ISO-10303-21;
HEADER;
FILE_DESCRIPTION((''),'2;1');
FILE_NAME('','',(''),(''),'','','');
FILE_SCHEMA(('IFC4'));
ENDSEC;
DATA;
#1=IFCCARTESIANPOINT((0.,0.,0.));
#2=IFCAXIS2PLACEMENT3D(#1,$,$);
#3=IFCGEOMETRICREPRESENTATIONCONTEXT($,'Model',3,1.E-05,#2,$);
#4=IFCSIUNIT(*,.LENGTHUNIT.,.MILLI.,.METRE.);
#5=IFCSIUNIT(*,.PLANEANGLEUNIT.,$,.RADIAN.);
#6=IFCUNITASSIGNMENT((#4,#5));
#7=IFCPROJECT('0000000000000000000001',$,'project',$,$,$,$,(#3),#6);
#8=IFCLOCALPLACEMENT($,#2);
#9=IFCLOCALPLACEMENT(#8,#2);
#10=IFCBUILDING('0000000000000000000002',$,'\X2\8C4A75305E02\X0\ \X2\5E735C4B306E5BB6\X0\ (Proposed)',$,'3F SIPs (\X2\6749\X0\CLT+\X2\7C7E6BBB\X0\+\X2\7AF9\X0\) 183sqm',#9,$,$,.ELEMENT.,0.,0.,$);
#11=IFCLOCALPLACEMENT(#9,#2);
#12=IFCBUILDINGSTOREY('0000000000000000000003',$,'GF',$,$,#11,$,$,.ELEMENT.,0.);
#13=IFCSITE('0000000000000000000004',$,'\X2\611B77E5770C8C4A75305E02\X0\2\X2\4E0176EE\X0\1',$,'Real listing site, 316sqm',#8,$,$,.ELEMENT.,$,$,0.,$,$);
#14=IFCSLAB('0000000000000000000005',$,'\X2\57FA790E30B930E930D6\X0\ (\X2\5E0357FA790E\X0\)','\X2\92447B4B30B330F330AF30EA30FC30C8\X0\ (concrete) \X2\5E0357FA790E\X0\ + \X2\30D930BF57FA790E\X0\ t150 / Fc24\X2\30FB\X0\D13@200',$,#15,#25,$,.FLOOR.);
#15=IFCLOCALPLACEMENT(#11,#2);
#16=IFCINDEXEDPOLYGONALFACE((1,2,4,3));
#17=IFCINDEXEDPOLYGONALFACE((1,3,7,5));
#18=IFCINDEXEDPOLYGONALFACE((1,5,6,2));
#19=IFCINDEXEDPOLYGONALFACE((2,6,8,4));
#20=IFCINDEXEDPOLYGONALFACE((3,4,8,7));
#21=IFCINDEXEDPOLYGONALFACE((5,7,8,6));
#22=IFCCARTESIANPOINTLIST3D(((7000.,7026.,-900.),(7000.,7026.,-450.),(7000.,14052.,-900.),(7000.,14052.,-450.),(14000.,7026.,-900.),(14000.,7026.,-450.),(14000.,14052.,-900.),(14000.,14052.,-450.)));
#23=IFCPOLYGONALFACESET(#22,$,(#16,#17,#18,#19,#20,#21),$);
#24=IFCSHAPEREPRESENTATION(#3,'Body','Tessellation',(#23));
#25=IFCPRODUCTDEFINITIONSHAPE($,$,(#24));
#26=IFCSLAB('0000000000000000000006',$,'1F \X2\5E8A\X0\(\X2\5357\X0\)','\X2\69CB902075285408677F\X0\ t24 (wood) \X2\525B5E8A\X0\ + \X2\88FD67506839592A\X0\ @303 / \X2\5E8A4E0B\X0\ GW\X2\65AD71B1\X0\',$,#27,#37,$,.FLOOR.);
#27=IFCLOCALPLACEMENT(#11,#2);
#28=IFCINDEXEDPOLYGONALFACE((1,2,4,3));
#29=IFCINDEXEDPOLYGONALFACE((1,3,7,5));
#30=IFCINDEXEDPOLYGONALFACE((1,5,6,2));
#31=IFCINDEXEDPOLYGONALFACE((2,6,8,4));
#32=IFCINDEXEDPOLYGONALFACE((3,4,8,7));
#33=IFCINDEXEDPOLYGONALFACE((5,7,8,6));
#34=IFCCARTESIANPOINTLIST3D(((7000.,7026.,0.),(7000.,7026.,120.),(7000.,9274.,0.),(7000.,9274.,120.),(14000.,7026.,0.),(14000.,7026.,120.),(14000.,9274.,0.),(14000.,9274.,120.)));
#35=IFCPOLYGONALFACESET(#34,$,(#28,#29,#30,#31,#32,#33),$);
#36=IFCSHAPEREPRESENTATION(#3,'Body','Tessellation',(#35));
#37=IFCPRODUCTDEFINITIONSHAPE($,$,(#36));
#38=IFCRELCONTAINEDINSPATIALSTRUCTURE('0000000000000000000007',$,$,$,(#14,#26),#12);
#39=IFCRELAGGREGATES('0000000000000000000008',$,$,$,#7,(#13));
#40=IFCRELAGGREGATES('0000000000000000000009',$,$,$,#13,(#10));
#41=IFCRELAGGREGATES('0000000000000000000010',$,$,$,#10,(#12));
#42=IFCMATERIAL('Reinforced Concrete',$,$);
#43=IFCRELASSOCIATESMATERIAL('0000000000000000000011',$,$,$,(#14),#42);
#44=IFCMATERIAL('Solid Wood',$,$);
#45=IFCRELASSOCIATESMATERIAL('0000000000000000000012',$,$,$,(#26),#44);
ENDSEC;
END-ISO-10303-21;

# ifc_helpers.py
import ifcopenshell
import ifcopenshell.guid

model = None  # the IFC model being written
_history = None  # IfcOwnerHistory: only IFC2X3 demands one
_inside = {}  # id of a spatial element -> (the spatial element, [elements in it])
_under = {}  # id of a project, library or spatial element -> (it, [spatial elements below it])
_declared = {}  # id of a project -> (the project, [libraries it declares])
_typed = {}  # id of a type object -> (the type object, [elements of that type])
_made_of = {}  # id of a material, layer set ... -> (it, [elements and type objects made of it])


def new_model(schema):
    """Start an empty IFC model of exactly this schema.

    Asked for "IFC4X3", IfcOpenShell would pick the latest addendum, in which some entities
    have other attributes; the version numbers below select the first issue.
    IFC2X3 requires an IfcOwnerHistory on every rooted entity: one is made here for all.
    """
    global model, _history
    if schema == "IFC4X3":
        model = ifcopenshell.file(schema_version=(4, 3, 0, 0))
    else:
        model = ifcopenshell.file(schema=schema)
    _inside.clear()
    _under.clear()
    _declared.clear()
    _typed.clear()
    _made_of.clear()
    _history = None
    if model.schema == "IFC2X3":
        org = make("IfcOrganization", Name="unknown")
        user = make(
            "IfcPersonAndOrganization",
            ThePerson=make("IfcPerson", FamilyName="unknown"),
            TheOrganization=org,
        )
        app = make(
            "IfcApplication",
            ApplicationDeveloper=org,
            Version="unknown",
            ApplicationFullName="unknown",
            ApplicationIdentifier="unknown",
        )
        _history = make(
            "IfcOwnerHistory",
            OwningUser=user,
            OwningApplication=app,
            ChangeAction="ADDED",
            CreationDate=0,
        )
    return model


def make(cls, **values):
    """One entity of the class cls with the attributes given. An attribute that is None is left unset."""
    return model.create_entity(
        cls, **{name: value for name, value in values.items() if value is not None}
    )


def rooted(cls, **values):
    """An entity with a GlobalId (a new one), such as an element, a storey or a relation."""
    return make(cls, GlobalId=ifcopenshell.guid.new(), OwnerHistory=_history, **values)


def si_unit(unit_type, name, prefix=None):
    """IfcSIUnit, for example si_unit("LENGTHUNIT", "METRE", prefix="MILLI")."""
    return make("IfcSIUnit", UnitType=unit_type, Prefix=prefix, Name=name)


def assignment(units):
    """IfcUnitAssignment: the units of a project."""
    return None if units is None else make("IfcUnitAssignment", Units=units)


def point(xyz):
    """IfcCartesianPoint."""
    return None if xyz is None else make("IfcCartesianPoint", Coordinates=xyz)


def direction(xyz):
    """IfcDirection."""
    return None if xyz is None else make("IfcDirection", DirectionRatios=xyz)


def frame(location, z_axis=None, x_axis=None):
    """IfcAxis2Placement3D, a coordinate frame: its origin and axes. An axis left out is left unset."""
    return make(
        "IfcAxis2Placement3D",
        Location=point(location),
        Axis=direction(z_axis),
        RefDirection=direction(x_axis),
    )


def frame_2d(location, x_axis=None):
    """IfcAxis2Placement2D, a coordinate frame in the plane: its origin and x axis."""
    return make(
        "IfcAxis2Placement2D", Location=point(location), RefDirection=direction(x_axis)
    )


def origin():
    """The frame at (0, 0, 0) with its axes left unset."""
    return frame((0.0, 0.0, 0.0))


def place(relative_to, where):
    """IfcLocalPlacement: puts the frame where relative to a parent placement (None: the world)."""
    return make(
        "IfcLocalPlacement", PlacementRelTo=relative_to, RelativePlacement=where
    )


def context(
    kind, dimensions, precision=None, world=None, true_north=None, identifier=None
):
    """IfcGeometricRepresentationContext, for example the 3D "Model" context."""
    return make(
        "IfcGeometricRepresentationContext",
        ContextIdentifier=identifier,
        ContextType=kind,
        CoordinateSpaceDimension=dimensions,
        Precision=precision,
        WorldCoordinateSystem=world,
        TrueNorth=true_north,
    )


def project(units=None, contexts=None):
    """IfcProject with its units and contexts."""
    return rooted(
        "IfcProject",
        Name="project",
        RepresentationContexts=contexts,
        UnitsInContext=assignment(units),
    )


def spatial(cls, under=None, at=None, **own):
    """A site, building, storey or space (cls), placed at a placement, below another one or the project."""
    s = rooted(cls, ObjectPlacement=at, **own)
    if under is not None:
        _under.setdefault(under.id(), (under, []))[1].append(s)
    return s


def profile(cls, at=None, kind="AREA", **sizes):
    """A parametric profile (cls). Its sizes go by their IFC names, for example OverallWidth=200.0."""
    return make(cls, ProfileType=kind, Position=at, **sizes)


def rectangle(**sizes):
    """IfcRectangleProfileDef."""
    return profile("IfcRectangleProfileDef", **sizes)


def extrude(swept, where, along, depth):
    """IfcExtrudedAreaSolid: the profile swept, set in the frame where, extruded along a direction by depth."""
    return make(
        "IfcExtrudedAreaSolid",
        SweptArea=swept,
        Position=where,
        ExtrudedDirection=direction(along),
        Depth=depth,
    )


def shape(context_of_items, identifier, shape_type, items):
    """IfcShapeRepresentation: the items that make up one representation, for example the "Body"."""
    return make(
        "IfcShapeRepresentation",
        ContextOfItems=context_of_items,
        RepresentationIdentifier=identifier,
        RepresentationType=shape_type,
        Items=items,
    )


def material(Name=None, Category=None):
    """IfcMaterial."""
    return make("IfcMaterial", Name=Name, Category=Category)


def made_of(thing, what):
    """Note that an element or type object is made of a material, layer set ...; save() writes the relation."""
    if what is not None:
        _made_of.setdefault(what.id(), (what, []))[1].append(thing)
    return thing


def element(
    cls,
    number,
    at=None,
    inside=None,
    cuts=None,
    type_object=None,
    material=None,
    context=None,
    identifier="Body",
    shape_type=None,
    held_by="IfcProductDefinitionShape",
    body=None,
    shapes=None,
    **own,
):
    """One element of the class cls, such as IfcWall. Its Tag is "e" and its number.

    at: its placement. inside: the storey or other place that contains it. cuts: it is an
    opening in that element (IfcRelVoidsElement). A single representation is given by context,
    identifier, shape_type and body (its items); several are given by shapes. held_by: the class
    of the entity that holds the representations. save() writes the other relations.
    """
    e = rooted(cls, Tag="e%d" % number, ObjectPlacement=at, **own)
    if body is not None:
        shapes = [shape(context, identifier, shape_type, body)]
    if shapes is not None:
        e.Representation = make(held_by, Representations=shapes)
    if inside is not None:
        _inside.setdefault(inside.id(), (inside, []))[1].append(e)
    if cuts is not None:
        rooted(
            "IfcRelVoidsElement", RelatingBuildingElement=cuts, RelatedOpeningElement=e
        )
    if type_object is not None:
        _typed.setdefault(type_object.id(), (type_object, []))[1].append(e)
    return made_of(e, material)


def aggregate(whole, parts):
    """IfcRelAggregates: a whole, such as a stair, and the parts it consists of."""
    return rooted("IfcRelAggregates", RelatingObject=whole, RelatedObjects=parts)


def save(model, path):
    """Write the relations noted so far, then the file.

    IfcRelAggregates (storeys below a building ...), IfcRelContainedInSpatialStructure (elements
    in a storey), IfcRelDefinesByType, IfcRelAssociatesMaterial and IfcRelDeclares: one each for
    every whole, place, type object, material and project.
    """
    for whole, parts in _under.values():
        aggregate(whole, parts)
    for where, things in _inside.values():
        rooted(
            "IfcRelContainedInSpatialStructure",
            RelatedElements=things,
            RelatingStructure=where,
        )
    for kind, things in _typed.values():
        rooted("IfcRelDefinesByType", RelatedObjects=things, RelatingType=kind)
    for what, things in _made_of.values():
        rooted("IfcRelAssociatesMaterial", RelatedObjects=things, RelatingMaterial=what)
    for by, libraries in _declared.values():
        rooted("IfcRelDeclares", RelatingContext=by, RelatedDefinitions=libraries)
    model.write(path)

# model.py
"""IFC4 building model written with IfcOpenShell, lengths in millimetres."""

from ifc_helpers import new_model, si_unit, frame, frame_2d, origin, place, context, project, spatial, rectangle, extrude, material, element, save


model = new_model("IFC4")

# Units and contexts
model_context = context("Model", 3, precision=1e-05, world=origin())
ifc_project = project(units=[si_unit("LENGTHUNIT", "METRE", prefix="MILLI"), si_unit("PLANEANGLEUNIT", "RADIAN")], contexts=[model_context])

# Site, building, storey
site_placement = place(None, origin())
site = spatial("IfcSite", under=ifc_project, at=site_placement, Name="愛知県豊田市2丁目1", ObjectType="Real listing site, 316sqm", CompositionType="ELEMENT", RefElevation=0.0)
building_placement = place(site_placement, origin())
building = spatial("IfcBuilding", under=site, at=building_placement, Name="豊田市 平屋の家 (Proposed)", ObjectType="3F SIPs (杉CLT+籾殻+竹) 183sqm", CompositionType="ELEMENT", ElevationOfRefHeight=0.0, ElevationOfTerrain=0.0)
storey_placement = place(building_placement, origin())
storey = spatial("IfcBuildingStorey", under=building, at=storey_placement, Name="GF", CompositionType="ELEMENT", Elevation=0.0)

# Slabs
ifc_material_1 = material(Name="Reinforced Concrete")
slab_1_placement = place(storey_placement, frame((3500.0, 3513.0, -450.0)))
element("IfcSlab", 1, at=slab_1_placement, inside=storey, material=ifc_material_1, Name="基礎スラブ (布基礎)", Description="鉄筋コンクリート (concrete) 布基礎 + ベタ基礎 t150 / Fc24・D13@200", PredefinedType="FLOOR", context=model_context, shape_type="SweptSolid", body=[
    extrude(rectangle(XDim=7000.0, YDim=7026.0, at=frame_2d((3500.0, 3513.0))), frame((3500.0, 3513.0, -450.0)), (0.0, 0.0, 1.0), 450.0),
])
ifc_material_2 = material(Name="Solid Wood")
slab_2_placement = place(storey_placement, frame((3500.0, 3513.0, 0.0)))
element("IfcSlab", 2, at=slab_2_placement, inside=storey, material=ifc_material_2, Name="1F 床(南)", Description="構造用合板 t24 (wood) 剛床 + 製材根太 @303 / 床下 GW断熱", PredefinedType="FLOOR", context=model_context, shape_type="SweptSolid", body=[
    extrude(rectangle(XDim=7000.0, YDim=2248.0, at=frame_2d((3500.0, 1124.0))), frame((3500.0, 3513.0, 0.0)), (0.0, 0.0, 1.0), 120.0),
])

save(model, "model.ifc")
